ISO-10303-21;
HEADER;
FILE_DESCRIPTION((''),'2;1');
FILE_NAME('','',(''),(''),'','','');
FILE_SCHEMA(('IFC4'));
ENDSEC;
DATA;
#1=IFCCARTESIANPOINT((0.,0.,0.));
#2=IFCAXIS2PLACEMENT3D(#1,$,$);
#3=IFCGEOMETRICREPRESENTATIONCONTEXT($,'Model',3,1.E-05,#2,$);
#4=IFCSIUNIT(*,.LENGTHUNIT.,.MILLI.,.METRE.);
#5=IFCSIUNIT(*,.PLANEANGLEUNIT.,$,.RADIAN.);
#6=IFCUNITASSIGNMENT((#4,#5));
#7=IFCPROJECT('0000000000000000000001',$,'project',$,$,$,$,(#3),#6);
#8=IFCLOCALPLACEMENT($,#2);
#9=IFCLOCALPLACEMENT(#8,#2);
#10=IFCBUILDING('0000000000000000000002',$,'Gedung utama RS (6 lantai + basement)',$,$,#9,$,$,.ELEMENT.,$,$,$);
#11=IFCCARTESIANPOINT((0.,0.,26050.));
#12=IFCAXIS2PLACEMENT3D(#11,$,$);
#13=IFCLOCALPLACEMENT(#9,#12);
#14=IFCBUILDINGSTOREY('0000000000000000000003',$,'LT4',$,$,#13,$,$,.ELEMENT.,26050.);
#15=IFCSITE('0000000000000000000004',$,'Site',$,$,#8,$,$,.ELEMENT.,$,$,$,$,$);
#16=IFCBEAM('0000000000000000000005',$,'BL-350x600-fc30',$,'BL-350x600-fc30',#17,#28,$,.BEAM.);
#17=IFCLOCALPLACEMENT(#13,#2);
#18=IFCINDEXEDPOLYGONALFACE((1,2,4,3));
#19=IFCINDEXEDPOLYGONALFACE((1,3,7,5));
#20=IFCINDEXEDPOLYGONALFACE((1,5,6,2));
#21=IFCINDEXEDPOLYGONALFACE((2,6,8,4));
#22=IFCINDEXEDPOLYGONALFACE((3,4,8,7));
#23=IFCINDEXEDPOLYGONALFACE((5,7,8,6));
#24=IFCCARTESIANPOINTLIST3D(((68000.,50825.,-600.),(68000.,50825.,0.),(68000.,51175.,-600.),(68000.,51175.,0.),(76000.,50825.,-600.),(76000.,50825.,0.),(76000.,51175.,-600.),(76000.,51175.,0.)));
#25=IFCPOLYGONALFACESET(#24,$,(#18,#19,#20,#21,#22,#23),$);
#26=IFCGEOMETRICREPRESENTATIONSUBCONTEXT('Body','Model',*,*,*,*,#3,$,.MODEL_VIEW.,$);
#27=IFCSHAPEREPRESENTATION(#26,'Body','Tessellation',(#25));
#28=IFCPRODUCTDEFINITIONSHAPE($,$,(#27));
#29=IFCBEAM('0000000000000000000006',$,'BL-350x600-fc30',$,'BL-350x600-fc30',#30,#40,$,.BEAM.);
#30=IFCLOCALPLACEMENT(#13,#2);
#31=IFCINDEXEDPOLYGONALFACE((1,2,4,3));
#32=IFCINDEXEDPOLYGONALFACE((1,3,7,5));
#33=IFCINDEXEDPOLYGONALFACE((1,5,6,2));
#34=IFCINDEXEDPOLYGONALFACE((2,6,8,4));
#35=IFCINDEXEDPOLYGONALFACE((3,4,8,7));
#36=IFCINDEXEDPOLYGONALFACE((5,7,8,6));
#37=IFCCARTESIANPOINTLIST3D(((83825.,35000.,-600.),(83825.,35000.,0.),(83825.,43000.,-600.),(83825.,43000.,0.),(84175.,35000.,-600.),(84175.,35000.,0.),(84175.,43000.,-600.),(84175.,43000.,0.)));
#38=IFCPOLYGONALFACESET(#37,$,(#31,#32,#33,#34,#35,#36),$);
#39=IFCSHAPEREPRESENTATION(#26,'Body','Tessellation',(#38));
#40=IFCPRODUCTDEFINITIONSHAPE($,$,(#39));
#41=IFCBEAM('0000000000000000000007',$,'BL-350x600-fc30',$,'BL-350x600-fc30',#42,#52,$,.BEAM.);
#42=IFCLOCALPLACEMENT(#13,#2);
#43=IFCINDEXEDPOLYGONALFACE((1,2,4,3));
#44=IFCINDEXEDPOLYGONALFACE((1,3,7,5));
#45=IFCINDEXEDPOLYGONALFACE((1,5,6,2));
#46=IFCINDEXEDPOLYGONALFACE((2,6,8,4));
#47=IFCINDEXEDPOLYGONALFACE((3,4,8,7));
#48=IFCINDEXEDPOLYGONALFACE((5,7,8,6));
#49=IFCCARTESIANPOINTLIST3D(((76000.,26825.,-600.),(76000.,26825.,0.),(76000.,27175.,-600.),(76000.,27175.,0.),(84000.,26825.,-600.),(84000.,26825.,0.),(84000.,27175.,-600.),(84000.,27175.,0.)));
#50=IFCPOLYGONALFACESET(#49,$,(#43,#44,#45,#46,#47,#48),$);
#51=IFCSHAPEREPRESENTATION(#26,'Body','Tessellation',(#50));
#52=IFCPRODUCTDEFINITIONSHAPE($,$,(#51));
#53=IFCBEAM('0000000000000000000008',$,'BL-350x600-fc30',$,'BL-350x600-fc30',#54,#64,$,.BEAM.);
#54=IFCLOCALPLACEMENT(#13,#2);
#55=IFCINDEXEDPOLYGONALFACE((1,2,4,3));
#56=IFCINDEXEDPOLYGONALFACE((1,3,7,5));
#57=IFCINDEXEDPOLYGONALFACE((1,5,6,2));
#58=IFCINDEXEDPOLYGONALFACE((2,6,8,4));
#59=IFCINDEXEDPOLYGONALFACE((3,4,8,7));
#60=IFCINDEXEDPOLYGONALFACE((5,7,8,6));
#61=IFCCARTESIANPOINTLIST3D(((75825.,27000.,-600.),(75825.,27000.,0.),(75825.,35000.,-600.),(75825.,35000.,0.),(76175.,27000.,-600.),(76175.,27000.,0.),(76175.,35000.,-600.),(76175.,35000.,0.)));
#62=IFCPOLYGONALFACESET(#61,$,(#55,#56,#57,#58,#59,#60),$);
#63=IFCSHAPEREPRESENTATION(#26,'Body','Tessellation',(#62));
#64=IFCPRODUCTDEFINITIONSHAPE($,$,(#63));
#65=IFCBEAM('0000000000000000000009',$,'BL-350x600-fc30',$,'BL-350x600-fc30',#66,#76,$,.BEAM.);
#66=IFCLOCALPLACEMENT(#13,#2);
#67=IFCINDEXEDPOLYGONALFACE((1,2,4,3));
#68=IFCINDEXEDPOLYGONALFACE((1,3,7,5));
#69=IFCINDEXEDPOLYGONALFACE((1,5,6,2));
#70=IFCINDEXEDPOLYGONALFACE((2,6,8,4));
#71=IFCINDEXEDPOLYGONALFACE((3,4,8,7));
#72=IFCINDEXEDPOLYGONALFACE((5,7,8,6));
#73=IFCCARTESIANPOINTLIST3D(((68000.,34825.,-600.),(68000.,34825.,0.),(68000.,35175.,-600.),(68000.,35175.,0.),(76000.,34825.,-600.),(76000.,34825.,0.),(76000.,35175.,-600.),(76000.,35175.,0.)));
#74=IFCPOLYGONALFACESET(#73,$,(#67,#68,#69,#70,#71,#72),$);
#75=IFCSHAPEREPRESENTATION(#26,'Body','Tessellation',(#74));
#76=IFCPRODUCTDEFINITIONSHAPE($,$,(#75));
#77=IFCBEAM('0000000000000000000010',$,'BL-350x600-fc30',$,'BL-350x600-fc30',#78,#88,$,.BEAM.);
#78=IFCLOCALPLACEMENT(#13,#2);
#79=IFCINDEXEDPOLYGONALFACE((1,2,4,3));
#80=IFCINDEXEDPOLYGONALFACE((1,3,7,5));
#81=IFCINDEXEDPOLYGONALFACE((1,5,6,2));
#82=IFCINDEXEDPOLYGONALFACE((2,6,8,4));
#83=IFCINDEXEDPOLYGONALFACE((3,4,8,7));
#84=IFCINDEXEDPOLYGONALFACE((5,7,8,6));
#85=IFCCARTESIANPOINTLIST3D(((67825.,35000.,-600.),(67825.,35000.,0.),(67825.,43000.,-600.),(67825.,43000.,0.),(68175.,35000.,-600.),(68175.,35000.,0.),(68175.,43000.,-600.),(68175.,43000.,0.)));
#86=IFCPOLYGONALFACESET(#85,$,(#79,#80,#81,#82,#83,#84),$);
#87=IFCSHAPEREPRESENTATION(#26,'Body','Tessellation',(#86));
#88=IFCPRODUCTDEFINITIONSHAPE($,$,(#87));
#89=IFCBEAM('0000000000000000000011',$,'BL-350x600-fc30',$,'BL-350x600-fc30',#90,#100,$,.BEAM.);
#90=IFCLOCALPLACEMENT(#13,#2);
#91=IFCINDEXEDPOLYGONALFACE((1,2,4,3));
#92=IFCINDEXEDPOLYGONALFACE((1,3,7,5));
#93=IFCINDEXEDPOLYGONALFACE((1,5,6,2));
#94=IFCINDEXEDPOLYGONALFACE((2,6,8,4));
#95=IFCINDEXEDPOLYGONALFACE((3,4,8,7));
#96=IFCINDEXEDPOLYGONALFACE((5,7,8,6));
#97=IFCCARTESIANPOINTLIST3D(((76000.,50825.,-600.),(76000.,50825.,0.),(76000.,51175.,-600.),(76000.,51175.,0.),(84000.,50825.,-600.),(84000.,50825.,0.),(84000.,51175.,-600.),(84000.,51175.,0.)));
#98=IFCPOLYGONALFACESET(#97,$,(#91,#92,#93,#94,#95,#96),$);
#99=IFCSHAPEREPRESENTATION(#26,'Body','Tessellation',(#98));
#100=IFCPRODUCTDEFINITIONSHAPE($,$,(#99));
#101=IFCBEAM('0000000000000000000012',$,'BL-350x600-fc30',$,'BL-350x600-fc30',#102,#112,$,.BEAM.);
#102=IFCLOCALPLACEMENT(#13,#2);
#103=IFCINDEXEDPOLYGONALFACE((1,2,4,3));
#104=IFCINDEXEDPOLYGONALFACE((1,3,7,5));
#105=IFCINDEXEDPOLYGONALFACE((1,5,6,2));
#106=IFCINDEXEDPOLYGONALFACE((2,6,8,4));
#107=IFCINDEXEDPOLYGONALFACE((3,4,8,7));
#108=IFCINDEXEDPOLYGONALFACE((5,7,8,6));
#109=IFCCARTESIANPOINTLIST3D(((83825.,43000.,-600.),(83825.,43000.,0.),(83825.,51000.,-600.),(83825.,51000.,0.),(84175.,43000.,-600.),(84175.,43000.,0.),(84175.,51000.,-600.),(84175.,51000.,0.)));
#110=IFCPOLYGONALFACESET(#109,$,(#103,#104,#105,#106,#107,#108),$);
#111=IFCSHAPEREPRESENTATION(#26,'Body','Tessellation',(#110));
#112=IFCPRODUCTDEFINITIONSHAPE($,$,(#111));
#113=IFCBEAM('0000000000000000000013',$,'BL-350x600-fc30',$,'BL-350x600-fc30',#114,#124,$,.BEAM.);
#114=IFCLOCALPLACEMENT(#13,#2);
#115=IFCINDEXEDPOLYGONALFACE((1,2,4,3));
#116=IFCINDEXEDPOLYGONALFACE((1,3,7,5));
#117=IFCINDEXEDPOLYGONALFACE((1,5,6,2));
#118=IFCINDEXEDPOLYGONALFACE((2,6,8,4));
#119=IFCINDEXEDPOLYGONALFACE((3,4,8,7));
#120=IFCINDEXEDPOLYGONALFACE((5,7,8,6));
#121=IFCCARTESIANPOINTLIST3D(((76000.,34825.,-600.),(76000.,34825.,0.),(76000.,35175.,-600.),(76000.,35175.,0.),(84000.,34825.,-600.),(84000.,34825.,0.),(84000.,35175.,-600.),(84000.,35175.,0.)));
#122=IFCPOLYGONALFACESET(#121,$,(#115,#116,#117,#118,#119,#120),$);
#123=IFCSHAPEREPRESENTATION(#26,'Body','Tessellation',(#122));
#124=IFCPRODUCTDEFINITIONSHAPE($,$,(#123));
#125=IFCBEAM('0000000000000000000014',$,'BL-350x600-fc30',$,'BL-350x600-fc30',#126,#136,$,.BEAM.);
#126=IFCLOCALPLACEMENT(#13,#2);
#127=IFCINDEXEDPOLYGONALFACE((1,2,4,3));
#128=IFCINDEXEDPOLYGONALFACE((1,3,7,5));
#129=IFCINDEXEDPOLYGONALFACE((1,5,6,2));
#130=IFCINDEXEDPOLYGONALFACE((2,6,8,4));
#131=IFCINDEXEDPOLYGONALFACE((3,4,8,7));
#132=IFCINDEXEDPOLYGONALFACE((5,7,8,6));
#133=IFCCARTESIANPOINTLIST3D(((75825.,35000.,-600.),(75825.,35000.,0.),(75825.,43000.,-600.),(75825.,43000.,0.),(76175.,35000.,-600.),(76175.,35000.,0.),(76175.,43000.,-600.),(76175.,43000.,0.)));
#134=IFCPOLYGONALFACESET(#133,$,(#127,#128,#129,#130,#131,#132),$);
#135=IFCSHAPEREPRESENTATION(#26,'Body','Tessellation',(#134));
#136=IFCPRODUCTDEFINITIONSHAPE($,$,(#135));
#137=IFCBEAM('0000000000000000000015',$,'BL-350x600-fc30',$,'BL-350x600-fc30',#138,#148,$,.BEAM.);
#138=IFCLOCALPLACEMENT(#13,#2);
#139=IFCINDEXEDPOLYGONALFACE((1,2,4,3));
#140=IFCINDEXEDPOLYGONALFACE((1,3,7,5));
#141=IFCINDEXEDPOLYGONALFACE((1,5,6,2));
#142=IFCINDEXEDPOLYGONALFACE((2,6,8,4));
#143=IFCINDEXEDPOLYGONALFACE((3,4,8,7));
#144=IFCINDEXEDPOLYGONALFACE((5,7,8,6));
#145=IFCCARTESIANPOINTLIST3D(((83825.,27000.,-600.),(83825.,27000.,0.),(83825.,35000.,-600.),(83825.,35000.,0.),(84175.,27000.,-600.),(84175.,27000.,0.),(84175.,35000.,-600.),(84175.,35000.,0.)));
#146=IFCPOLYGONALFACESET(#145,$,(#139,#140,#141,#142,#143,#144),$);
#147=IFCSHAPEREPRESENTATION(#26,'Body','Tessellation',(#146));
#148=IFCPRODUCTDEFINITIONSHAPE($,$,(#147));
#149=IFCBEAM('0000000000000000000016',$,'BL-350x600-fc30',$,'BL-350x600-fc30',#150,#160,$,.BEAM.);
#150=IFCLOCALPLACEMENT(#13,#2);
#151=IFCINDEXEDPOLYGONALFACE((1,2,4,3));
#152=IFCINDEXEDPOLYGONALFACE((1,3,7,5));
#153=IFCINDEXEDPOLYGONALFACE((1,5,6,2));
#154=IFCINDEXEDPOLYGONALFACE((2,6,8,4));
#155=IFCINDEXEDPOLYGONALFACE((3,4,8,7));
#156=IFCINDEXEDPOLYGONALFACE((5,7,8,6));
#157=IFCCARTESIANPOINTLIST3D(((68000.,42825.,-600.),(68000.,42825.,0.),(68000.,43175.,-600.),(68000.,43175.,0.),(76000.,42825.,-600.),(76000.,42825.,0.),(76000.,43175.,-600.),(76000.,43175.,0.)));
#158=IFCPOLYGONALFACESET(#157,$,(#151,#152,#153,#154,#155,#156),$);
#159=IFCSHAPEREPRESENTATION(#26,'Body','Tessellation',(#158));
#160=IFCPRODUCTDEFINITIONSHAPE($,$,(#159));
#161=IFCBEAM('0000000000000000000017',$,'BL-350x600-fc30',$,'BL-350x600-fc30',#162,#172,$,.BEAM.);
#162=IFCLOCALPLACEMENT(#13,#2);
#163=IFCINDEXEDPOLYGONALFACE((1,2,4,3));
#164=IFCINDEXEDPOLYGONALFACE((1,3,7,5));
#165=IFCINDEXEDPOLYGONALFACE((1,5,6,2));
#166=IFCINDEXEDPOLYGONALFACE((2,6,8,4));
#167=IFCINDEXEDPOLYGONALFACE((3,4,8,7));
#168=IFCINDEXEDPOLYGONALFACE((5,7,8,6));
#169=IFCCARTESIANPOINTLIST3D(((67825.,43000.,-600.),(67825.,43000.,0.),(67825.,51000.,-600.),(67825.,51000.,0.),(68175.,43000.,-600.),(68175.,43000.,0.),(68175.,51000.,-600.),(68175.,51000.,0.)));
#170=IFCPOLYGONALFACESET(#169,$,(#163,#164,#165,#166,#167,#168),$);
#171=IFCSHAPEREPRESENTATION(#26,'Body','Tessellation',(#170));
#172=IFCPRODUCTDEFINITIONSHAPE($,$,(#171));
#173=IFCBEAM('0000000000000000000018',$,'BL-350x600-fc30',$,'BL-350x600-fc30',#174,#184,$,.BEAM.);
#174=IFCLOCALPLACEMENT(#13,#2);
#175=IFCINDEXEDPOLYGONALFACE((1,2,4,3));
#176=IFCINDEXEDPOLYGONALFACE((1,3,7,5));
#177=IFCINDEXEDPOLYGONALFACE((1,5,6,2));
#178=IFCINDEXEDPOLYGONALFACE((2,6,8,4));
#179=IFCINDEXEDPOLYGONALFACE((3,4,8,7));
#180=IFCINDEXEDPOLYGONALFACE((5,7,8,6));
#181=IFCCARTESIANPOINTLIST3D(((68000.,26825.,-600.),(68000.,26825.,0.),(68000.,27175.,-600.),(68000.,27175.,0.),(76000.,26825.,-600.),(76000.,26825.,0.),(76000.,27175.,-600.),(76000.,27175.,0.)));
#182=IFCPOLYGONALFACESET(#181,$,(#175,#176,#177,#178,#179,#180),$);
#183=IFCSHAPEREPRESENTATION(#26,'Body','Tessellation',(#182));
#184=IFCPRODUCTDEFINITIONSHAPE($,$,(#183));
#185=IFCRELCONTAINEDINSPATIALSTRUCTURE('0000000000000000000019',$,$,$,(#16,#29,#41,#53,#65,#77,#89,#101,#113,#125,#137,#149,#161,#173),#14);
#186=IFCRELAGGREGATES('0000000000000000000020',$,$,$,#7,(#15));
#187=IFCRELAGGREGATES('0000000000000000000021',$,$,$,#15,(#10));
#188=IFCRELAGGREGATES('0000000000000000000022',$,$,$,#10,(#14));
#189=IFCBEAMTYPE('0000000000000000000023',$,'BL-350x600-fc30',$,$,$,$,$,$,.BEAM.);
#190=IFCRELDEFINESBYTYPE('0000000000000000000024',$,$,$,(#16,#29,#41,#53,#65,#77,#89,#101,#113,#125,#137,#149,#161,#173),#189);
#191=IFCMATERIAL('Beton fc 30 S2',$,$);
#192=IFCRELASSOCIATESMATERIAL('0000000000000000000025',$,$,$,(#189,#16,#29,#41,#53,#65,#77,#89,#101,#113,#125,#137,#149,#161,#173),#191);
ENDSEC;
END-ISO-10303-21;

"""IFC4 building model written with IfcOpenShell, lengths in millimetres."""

from ifc_helpers import new_model, si_unit, frame, origin, origin_2d, place, context, subcontext, project, spatial, rectangle, extrude, material, material_profile, profile_set, profile_usage, type_object, element, save


model = new_model("IFC4")

# Units and contexts
model_context = context("Model", 3, precision=1e-05, world=origin())
body_context = subcontext(model_context, "Body", "Model", "MODEL_VIEW")
ifc_project = project(units=[si_unit("LENGTHUNIT", "METRE", prefix="MILLI"), si_unit("PLANEANGLEUNIT", "RADIAN")], contexts=[model_context])

# Site, building, storey
site_placement = place(None, origin())
site = spatial("IfcSite", under=ifc_project, at=site_placement, Name="Site", CompositionType="ELEMENT")
building_placement = place(site_placement, origin())
building = spatial("IfcBuilding", under=site, at=building_placement, Name="Gedung utama RS (6 lantai + basement)", CompositionType="ELEMENT")
storey_placement = place(building_placement, frame((0.0, 0.0, 26050.0)))
storey = spatial("IfcBuildingStorey", under=building, at=storey_placement, Name="LT4", CompositionType="ELEMENT", Elevation=26050.0)

# Beams
ifc_material_1 = material(Name="Beton fc 30 S2")
ifc_material_profile_1 = material_profile(ifc_material_1, rectangle(XDim=350.0, YDim=600.0, at=origin_2d()), Name="BL-350x600-fc30")
ifc_profile_set_1 = profile_set([ifc_material_profile_1], Name="BL-350x600-fc30")
ifc_profile_usage_1 = profile_usage(ifc_profile_set_1, cardinal=8)
beam_type = type_object("IfcBeamType", Name="BL-350x600-fc30", PredefinedType="BEAM", material=ifc_profile_set_1)
beam_1_placement = place(storey_placement, frame((68000.0, 51000.0, -300.0)))
element("IfcBeam", 1, at=beam_1_placement, inside=storey, type_object=beam_type, material=ifc_profile_usage_1, Name="BL-350x600-fc30", ObjectType="BL-350x600-fc30", PredefinedType="BEAM", context=body_context, shape_type="SweptSolid", body=[
    extrude(rectangle(XDim=350.0, YDim=600.0, at=origin_2d()), frame((0.0, 0.0, 0.0), z_axis=(1.0, 0.0, 0.0), x_axis=(0.0, 1.0, 0.0)), (0.0, 0.0, 1.0), 8000.0),
])
beam_2_placement = place(storey_placement, frame((84000.0, 35000.0, -300.0)))
element("IfcBeam", 2, at=beam_2_placement, inside=storey, type_object=beam_type, material=ifc_profile_usage_1, Name="BL-350x600-fc30", ObjectType="BL-350x600-fc30", PredefinedType="BEAM", context=body_context, shape_type="SweptSolid", body=[
    extrude(rectangle(XDim=350.0, YDim=600.0, at=origin_2d()), frame((0.0, 0.0, 0.0), z_axis=(0.0, 1.0, 0.0), x_axis=(-1.0, 0.0, 0.0)), (0.0, 0.0, 1.0), 8000.0),
])
beam_3_placement = place(storey_placement, frame((76000.0, 27000.0, -300.0)))
element("IfcBeam", 3, at=beam_3_placement, inside=storey, type_object=beam_type, material=ifc_profile_usage_1, Name="BL-350x600-fc30", ObjectType="BL-350x600-fc30", PredefinedType="BEAM", context=body_context, shape_type="SweptSolid", body=[
    extrude(rectangle(XDim=350.0, YDim=600.0, at=origin_2d()), frame((0.0, 0.0, 0.0), z_axis=(1.0, 0.0, 0.0), x_axis=(0.0, 1.0, 0.0)), (0.0, 0.0, 1.0), 8000.0),
])
beam_4_placement = place(storey_placement, frame((76000.0, 27000.0, -300.0)))
element("IfcBeam", 4, at=beam_4_placement, inside=storey, type_object=beam_type, material=ifc_profile_usage_1, Name="BL-350x600-fc30", ObjectType="BL-350x600-fc30", PredefinedType="BEAM", context=body_context, shape_type="SweptSolid", body=[
    extrude(rectangle(XDim=350.0, YDim=600.0, at=origin_2d()), frame((0.0, 0.0, 0.0), z_axis=(0.0, 1.0, 0.0), x_axis=(-1.0, 0.0, 0.0)), (0.0, 0.0, 1.0), 8000.0),
])
beam_5_placement = place(storey_placement, frame((68000.0, 35000.0, -300.0)))
element("IfcBeam", 5, at=beam_5_placement, inside=storey, type_object=beam_type, material=ifc_profile_usage_1, Name="BL-350x600-fc30", ObjectType="BL-350x600-fc30", PredefinedType="BEAM", context=body_context, shape_type="SweptSolid", body=[
    extrude(rectangle(XDim=350.0, YDim=600.0, at=origin_2d()), frame((0.0, 0.0, 0.0), z_axis=(1.0, 0.0, 0.0), x_axis=(0.0, 1.0, 0.0)), (0.0, 0.0, 1.0), 8000.0),
])
beam_6_placement = place(storey_placement, frame((68000.0, 35000.0, -300.0)))
element("IfcBeam", 6, at=beam_6_placement, inside=storey, type_object=beam_type, material=ifc_profile_usage_1, Name="BL-350x600-fc30", ObjectType="BL-350x600-fc30", PredefinedType="BEAM", context=body_context, shape_type="SweptSolid", body=[
    extrude(rectangle(XDim=350.0, YDim=600.0, at=origin_2d()), frame((0.0, 0.0, 0.0), z_axis=(0.0, 1.0, 0.0), x_axis=(-1.0, 0.0, 0.0)), (0.0, 0.0, 1.0), 8000.0),
])
beam_7_placement = place(storey_placement, frame((76000.0, 51000.0, -300.0)))
element("IfcBeam", 7, at=beam_7_placement, inside=storey, type_object=beam_type, material=ifc_profile_usage_1, Name="BL-350x600-fc30", ObjectType="BL-350x600-fc30", PredefinedType="BEAM", context=body_context, shape_type="SweptSolid", body=[
    extrude(rectangle(XDim=350.0, YDim=600.0, at=origin_2d()), frame((0.0, 0.0, 0.0), z_axis=(1.0, 0.0, 0.0), x_axis=(0.0, 1.0, 0.0)), (0.0, 0.0, 1.0), 8000.0),
])
beam_8_placement = place(storey_placement, frame((84000.0, 43000.0, -300.0)))
element("IfcBeam", 8, at=beam_8_placement, inside=storey, type_object=beam_type, material=ifc_profile_usage_1, Name="BL-350x600-fc30", ObjectType="BL-350x600-fc30", PredefinedType="BEAM", context=body_context, shape_type="SweptSolid", body=[
    extrude(rectangle(XDim=350.0, YDim=600.0, at=origin_2d()), frame((0.0, 0.0, 0.0), z_axis=(0.0, 1.0, 0.0), x_axis=(-1.0, 0.0, 0.0)), (0.0, 0.0, 1.0), 8000.0),
])
beam_9_placement = place(storey_placement, frame((76000.0, 35000.0, -300.0)))
element("IfcBeam", 9, at=beam_9_placement, inside=storey, type_object=beam_type, material=ifc_profile_usage_1, Name="BL-350x600-fc30", ObjectType="BL-350x600-fc30", PredefinedType="BEAM", context=body_context, shape_type="SweptSolid", body=[
    extrude(rectangle(XDim=350.0, YDim=600.0, at=origin_2d()), frame((0.0, 0.0, 0.0), z_axis=(1.0, 0.0, 0.0), x_axis=(0.0, 1.0, 0.0)), (0.0, 0.0, 1.0), 8000.0),
])
for number, where, name in (
    (10, (76000.0, 35000.0, -300.0), "BL-350x600-fc30"),
    (11, (84000.0, 27000.0, -300.0), "BL-350x600-fc30"),
):
    element("IfcBeam", number, at=place(storey_placement, frame(where)), inside=storey, type_object=beam_type, material=ifc_profile_usage_1, Name=name, ObjectType="BL-350x600-fc30", PredefinedType="BEAM", context=body_context, shape_type="SweptSolid", body=[
        extrude(rectangle(XDim=350.0, YDim=600.0, at=origin_2d()), frame((0.0, 0.0, 0.0), z_axis=(0.0, 1.0, 0.0), x_axis=(-1.0, 0.0, 0.0)), (0.0, 0.0, 1.0), 8000.0),
    ])
beam_10_placement = place(storey_placement, frame((68000.0, 43000.0, -300.0)))
element("IfcBeam", 12, at=beam_10_placement, inside=storey, type_object=beam_type, material=ifc_profile_usage_1, Name="BL-350x600-fc30", ObjectType="BL-350x600-fc30", PredefinedType="BEAM", context=body_context, shape_type="SweptSolid", body=[
    extrude(rectangle(XDim=350.0, YDim=600.0, at=origin_2d()), frame((0.0, 0.0, 0.0), z_axis=(1.0, 0.0, 0.0), x_axis=(0.0, 1.0, 0.0)), (0.0, 0.0, 1.0), 8000.0),
])
beam_11_placement = place(storey_placement, frame((68000.0, 43000.0, -300.0)))
element("IfcBeam", 13, at=beam_11_placement, inside=storey, type_object=beam_type, material=ifc_profile_usage_1, Name="BL-350x600-fc30", ObjectType="BL-350x600-fc30", PredefinedType="BEAM", context=body_context, shape_type="SweptSolid", body=[
    extrude(rectangle(XDim=350.0, YDim=600.0, at=origin_2d()), frame((0.0, 0.0, 0.0), z_axis=(0.0, 1.0, 0.0), x_axis=(-1.0, 0.0, 0.0)), (0.0, 0.0, 1.0), 8000.0),
])
beam_12_placement = place(storey_placement, frame((68000.0, 27000.0, -300.0)))
element("IfcBeam", 14, at=beam_12_placement, inside=storey, type_object=beam_type, material=ifc_profile_usage_1, Name="BL-350x600-fc30", ObjectType="BL-350x600-fc30", PredefinedType="BEAM", context=body_context, shape_type="SweptSolid", body=[
    extrude(rectangle(XDim=350.0, YDim=600.0, at=origin_2d()), frame((0.0, 0.0, 0.0), z_axis=(1.0, 0.0, 0.0), x_axis=(0.0, 1.0, 0.0)), (0.0, 0.0, 1.0), 8000.0),
])

save(model, "model.ifc")
